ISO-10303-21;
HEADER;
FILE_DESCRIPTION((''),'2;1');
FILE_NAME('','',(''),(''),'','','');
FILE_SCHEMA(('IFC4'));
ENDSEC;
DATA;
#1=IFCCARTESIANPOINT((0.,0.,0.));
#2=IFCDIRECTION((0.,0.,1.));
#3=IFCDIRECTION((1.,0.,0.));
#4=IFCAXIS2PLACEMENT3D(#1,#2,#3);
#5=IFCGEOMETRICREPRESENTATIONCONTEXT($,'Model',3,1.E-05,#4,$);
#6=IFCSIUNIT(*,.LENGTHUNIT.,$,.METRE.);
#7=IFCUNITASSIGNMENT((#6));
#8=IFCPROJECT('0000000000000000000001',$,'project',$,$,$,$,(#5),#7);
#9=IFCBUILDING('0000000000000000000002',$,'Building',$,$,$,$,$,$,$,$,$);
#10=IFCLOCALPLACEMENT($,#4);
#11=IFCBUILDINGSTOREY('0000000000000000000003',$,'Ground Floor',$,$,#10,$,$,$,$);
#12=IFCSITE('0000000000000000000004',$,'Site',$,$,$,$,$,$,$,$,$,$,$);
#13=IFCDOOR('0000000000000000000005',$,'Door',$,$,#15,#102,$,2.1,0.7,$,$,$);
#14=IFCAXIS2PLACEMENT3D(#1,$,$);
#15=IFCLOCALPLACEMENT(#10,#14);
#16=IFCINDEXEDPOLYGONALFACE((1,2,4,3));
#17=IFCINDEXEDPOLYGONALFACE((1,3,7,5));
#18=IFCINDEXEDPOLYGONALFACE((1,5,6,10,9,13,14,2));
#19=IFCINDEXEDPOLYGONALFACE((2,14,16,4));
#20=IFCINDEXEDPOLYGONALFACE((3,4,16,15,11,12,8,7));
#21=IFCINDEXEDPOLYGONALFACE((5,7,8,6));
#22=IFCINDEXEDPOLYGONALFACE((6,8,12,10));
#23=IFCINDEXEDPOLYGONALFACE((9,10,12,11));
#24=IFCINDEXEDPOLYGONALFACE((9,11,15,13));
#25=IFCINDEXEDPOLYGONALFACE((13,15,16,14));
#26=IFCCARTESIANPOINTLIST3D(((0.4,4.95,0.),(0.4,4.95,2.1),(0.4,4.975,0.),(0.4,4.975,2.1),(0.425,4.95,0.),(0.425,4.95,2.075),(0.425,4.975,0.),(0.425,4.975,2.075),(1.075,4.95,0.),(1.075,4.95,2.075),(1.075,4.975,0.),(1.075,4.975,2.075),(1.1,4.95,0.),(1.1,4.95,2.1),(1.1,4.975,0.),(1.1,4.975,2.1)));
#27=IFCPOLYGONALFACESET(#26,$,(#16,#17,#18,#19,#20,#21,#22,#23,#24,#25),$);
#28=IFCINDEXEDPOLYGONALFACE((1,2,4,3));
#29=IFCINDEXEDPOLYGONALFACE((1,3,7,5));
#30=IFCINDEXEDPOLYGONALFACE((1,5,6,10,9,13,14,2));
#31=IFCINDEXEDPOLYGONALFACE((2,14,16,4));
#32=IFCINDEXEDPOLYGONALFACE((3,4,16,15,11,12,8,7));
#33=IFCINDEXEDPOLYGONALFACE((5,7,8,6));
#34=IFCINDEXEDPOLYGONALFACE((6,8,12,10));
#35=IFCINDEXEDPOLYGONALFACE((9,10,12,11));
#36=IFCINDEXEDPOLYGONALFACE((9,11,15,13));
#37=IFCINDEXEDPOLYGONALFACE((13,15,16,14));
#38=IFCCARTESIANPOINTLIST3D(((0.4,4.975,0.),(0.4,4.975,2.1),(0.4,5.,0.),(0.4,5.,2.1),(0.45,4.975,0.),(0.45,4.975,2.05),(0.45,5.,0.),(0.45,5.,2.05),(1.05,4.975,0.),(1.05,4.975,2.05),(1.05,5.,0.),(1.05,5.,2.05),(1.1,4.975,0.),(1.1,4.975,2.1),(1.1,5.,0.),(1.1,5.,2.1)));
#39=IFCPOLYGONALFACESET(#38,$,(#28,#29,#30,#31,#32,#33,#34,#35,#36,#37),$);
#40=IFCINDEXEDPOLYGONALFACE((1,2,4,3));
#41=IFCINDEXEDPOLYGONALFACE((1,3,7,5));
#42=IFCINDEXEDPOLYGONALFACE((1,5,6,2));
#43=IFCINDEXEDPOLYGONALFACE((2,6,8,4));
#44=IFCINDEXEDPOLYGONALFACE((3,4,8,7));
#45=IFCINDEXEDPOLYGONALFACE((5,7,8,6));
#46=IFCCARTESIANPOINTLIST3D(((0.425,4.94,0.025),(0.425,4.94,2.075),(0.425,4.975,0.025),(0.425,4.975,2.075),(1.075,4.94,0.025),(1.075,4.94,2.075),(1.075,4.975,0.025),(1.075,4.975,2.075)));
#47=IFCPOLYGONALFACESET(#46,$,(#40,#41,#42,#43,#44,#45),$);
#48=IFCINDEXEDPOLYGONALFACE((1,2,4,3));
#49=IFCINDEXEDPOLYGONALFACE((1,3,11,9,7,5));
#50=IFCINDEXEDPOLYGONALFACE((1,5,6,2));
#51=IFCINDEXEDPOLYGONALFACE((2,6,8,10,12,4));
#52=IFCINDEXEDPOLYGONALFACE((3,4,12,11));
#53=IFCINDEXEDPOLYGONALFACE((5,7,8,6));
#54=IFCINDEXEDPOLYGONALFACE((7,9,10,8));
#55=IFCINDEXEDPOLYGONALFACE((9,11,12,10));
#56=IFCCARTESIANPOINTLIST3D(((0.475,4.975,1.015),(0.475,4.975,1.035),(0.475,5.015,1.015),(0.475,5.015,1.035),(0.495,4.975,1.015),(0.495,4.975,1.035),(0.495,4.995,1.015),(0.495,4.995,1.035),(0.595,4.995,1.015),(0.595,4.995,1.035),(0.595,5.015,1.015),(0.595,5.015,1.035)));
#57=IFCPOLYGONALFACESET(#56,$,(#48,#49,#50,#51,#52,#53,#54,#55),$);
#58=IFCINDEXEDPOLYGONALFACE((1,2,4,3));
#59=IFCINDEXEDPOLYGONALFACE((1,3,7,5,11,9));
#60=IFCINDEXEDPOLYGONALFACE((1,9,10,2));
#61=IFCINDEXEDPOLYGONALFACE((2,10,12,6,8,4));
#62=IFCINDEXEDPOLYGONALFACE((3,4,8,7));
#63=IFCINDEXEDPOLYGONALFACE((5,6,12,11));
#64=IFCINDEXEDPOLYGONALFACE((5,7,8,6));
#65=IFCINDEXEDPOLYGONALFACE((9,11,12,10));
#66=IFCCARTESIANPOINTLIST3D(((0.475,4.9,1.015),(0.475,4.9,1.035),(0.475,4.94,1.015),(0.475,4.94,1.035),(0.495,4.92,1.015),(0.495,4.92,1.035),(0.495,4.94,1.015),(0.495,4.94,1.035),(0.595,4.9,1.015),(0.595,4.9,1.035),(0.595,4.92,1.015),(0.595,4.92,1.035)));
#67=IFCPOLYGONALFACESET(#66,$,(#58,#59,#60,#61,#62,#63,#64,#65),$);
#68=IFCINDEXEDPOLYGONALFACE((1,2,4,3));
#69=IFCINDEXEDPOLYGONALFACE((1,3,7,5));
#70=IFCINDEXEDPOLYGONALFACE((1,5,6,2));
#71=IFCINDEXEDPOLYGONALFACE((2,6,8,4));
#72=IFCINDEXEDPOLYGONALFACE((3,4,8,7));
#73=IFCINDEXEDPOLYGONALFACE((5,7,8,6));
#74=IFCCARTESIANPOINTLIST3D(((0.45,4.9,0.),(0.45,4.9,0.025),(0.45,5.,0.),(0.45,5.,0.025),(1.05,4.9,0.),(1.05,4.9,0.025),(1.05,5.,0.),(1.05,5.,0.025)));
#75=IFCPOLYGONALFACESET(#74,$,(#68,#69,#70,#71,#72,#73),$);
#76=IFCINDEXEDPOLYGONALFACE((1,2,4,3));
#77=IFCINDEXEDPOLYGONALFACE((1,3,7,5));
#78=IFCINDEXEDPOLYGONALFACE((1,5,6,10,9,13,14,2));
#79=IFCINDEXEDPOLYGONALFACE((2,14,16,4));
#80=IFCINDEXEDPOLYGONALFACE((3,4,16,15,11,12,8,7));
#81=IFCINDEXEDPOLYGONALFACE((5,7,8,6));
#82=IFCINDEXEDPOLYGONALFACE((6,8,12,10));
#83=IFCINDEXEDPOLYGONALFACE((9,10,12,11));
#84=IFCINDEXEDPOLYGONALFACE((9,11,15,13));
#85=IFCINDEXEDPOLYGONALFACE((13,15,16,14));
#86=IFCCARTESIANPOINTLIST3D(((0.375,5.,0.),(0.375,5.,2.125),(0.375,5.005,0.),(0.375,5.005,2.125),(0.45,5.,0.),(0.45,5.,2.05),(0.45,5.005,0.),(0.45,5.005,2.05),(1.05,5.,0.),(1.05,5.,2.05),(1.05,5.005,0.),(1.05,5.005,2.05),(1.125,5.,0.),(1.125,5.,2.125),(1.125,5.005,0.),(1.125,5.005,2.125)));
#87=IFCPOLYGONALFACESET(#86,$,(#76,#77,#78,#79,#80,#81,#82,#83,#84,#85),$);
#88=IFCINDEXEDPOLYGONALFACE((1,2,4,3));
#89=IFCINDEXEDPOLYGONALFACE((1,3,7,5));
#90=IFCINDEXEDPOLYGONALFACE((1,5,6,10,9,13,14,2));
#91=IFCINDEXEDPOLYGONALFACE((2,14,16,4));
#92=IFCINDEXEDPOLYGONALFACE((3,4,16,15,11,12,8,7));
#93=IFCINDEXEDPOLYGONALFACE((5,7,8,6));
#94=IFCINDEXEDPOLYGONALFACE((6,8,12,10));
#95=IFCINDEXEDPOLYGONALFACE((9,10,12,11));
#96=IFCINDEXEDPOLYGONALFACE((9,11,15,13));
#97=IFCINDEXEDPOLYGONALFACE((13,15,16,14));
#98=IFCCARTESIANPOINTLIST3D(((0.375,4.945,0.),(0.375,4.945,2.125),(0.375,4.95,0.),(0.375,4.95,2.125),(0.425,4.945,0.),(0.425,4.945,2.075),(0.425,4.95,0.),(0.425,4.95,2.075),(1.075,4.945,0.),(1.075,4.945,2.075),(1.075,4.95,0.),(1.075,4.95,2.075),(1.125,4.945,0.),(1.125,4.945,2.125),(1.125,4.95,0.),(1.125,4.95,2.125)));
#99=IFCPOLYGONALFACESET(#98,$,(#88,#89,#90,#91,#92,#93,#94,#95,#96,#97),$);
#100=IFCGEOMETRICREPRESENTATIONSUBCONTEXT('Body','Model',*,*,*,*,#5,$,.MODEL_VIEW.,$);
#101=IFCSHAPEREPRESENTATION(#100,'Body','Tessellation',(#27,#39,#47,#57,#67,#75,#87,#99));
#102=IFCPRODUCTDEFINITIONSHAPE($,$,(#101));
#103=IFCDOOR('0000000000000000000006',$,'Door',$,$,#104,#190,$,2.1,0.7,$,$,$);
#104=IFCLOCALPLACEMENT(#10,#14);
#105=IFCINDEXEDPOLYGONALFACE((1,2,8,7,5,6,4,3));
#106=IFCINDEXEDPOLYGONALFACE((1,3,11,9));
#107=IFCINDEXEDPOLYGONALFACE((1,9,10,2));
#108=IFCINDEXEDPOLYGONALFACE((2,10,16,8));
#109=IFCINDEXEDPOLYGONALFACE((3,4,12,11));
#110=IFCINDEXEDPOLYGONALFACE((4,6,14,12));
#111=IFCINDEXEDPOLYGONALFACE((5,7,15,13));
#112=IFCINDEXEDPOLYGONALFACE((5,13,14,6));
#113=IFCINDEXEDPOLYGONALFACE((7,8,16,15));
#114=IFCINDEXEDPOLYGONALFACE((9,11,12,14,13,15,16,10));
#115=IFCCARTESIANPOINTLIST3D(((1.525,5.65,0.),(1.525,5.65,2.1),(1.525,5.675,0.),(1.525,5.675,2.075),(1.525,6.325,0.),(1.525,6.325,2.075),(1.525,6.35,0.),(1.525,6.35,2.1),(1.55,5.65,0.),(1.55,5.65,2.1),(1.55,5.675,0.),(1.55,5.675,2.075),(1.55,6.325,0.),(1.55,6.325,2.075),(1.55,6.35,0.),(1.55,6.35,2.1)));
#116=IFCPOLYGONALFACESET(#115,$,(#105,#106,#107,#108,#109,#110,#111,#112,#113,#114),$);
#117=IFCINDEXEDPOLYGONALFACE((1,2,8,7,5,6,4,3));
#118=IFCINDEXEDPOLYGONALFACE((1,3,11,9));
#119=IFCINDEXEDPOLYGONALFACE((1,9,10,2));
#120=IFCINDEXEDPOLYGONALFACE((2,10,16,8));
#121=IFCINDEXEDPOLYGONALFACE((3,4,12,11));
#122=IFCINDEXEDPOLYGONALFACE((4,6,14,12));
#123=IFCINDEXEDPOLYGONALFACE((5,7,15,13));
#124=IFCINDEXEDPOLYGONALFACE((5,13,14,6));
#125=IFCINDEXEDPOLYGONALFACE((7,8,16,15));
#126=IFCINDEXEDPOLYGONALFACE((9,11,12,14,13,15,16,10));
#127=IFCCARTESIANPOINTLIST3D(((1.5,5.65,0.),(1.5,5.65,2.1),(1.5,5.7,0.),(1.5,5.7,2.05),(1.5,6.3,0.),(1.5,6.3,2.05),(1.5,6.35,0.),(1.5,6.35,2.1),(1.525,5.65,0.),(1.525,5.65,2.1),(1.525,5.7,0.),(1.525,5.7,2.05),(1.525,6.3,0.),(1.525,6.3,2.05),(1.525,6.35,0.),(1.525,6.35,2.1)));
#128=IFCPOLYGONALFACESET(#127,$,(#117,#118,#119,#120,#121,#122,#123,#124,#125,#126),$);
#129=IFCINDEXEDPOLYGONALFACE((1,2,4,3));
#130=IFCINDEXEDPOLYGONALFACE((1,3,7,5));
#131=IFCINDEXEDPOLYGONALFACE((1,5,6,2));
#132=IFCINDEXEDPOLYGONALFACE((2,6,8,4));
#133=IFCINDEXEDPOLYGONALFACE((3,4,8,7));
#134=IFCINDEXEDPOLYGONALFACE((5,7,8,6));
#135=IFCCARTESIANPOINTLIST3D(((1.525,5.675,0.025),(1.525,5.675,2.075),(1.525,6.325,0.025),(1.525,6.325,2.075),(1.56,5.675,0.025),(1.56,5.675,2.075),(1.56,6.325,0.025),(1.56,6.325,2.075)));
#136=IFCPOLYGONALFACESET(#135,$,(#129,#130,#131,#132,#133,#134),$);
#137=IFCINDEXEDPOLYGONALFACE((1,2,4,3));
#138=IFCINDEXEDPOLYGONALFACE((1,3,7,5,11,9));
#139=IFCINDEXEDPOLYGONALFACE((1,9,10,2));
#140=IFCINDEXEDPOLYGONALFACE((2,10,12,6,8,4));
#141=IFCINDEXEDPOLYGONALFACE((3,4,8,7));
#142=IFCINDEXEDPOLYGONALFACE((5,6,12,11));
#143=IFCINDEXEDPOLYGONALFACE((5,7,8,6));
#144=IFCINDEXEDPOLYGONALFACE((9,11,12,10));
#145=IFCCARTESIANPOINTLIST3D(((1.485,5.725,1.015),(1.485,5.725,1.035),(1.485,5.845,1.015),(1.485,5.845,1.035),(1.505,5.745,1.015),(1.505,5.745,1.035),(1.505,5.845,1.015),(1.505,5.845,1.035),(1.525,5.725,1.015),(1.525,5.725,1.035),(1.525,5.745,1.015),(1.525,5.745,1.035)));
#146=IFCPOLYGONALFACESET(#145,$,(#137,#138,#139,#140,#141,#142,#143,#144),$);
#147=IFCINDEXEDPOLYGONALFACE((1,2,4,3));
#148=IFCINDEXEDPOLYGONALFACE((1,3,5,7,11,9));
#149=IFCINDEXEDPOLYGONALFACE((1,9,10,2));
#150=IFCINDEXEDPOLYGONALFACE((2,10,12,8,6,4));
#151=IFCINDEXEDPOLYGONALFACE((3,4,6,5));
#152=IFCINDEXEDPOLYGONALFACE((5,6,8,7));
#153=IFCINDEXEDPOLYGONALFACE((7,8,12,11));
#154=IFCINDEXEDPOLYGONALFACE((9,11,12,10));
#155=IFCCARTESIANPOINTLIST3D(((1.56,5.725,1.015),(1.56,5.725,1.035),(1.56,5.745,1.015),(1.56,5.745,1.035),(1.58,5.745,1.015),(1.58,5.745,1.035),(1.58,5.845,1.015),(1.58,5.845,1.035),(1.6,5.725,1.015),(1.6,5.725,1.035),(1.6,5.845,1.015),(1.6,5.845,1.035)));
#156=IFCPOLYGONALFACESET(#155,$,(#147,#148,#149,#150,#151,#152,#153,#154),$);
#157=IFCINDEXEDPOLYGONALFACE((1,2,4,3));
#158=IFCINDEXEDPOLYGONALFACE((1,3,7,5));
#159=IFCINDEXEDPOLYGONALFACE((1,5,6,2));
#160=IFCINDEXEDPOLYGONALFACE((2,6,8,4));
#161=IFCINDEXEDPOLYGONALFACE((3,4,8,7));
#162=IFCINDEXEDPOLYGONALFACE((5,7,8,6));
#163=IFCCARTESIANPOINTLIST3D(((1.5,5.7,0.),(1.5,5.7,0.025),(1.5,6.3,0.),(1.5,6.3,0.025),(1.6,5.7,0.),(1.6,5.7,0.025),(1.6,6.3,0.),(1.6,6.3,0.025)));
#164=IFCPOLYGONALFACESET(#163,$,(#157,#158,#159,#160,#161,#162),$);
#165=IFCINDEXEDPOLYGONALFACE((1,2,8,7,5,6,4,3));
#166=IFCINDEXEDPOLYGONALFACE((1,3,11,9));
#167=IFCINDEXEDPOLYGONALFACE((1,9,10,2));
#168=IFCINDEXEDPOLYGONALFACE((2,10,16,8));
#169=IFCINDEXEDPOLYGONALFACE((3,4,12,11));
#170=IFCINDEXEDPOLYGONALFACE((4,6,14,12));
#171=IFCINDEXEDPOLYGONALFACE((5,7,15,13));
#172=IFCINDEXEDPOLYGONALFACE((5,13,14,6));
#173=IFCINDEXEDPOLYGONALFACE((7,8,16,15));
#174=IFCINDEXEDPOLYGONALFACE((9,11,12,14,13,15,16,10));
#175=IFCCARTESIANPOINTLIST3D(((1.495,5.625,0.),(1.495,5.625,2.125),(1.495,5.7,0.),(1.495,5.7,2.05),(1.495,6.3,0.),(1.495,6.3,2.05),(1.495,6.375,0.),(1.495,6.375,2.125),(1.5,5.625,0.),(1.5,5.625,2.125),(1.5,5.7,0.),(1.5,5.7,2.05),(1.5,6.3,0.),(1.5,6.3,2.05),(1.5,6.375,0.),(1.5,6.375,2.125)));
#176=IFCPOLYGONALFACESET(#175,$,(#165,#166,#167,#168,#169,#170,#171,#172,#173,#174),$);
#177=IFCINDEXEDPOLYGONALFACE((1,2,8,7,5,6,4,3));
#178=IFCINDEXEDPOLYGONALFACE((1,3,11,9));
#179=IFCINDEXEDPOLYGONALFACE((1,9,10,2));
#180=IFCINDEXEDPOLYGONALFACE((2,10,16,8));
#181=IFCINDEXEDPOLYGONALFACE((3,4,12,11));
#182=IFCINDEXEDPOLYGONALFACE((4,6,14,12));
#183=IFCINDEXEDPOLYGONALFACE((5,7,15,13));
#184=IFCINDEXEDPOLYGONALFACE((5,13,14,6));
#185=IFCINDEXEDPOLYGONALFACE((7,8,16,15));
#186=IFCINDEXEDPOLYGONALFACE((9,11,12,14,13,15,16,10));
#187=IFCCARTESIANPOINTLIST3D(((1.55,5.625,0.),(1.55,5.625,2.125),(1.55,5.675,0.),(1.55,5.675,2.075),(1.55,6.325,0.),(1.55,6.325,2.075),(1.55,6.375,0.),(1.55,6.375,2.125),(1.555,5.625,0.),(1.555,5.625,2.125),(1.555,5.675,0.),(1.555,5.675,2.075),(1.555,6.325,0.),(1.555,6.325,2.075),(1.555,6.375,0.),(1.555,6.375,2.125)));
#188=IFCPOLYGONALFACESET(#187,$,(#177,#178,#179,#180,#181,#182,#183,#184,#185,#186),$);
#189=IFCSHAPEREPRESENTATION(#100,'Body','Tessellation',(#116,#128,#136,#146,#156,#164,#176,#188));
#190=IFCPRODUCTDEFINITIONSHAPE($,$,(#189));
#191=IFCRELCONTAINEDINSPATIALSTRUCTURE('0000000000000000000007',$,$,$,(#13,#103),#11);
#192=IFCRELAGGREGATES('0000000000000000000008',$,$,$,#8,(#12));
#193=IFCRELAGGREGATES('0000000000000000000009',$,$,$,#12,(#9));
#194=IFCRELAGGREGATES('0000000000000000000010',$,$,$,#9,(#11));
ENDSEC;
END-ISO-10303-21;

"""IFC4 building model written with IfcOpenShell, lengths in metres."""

from ifc_helpers import new_model, si_unit, frame, origin_with_axes, place, context, subcontext, project, spatial, line, indexed_curve, outline, extrude, element, save


model = new_model("IFC4")

# Units and contexts
model_context = context("Model", 3, precision=1e-05, world=origin_with_axes())
body_context = subcontext(model_context, "Body", "Model", "MODEL_VIEW")
ifc_project = project(units=[si_unit("LENGTHUNIT", "METRE")], contexts=[model_context])

# Site, building, storey
site = spatial("IfcSite", under=ifc_project, Name="Site")
building = spatial("IfcBuilding", under=site, Name="Building")
storey_placement = place(None, origin_with_axes())
storey = spatial("IfcBuildingStorey", under=building, at=storey_placement, Name="Ground Floor")

# Doors
door_1_placement = place(storey_placement, frame((1.1, 5.0, 0.0), z_axis=(0.0, 0.0, 1.0), x_axis=(-1.0, 0.0, 0.0)))
element("IfcDoor", 1, at=door_1_placement, inside=storey, Name="Door", OverallHeight=2.1, OverallWidth=0.7, context=body_context, shape_type="SweptSolid", body=[
    extrude(outline(indexed_curve([(0.0, 0.0), (0.0, 2.1), (0.7, 2.1), (0.7, 0.0), (0.675, 0.0), (0.675, 2.075), (0.025, 2.075), (0.025, 0.0)], segments=[line(1, 2, 3, 4, 5, 6, 7, 8, 1)])), frame((0.0, 0.025, 0.0), z_axis=(0.0, -1.0, 0.0), x_axis=(1.0, 0.0, 0.0)), (0.0, 0.0, -1.0), 0.025),
    extrude(outline(indexed_curve([(0.0, 0.0), (0.0, 2.1), (0.7, 2.1), (0.7, 0.0), (0.65, 0.0), (0.65, 2.05), (0.05, 2.05), (0.05, 0.0)], segments=[line(1, 2, 3, 4, 5, 6, 7, 8, 1)])), frame((0.0, 0.0, 0.0), z_axis=(0.0, -1.0, 0.0), x_axis=(1.0, 0.0, 0.0)), (0.0, 0.0, -1.0), 0.025),
    extrude(outline(indexed_curve([(0.0, 0.0), (0.65, 0.0), (0.65, 0.035), (0.0, 0.035)], segments=[line(1, 2, 3, 4, 1)])), frame((0.025, 0.025, 0.025), z_axis=(0.0, 0.0, 1.0), x_axis=(1.0, 0.0, 0.0)), (0.0, 0.0, 1.0), 2.05),
    extrude(outline(indexed_curve([(0.0, 0.0), (0.0, -0.04), (-0.12, -0.04), (-0.12, -0.02), (-0.02, -0.02), (-0.02, 0.0)], segments=[line(1, 2, 3, 4, 5, 6, 1)])), frame((0.625, 0.025, 1.015), z_axis=(0.0, 0.0, 1.0), x_axis=(1.0, 0.0, 0.0)), (0.0, 0.0, 1.0), 0.02),
    extrude(outline(indexed_curve([(0.0, 0.0), (0.0, 0.04), (-0.12, 0.04), (-0.12, 0.02), (-0.02, 0.02), (-0.02, 0.0)], segments=[line(1, 2, 3, 4, 5, 6, 1)])), frame((0.625, 0.06, 1.015), z_axis=(0.0, 0.0, 1.0), x_axis=(1.0, 0.0, 0.0)), (0.0, 0.0, 1.0), 0.02),
    extrude(outline(indexed_curve([(0.0, 0.0), (0.6, 0.0), (0.6, 0.1), (0.0, 0.1)], segments=[line(1, 2, 3, 4, 1)])), frame((0.05, 0.0, 0.0), z_axis=(0.0, 0.0, 1.0), x_axis=(1.0, 0.0, 0.0)), (0.0, 0.0, 1.0), 0.025),
    extrude(outline(indexed_curve([(0.0, 0.0), (0.0, 2.125), (0.75, 2.125), (0.75, 0.0), (0.675, 0.0), (0.675, 2.05), (0.075, 2.05), (0.075, 0.0)], segments=[line(1, 2, 3, 4, 5, 6, 7, 8, 1)])), frame((-0.025, -0.005, 0.0), z_axis=(0.0, -1.0, 0.0), x_axis=(1.0, 0.0, 0.0)), (0.0, 0.0, -1.0), 0.005),
    extrude(outline(indexed_curve([(0.0, 0.0), (0.0, 2.125), (0.75, 2.125), (0.75, 0.0), (0.7, 0.0), (0.7, 2.075), (0.05, 2.075), (0.05, 0.0)], segments=[line(1, 2, 3, 4, 5, 6, 7, 8, 1)])), frame((-0.025, 0.05, 0.0), z_axis=(0.0, -1.0, 0.0), x_axis=(1.0, 0.0, 0.0)), (0.0, 0.0, -1.0), 0.005),
])
door_2_placement = place(storey_placement, frame((1.5, 6.35, 0.0), z_axis=(0.0, 0.0, 1.0), x_axis=(0.0, -1.0, 0.0)))
element("IfcDoor", 2, at=door_2_placement, inside=storey, Name="Door", OverallHeight=2.1, OverallWidth=0.7, context=body_context, shape_type="SweptSolid", body=[
    extrude(outline(indexed_curve([(0.0, 0.0), (0.0, 2.1), (0.7, 2.1), (0.7, 0.0), (0.675, 0.0), (0.675, 2.075), (0.025, 2.075), (0.025, 0.0)], segments=[line(1, 2, 3, 4, 5, 6, 7, 8, 1)])), frame((0.0, 0.025, 0.0), z_axis=(0.0, -1.0, 0.0), x_axis=(1.0, 0.0, 0.0)), (0.0, 0.0, -1.0), 0.025),
    extrude(outline(indexed_curve([(0.0, 0.0), (0.0, 2.1), (0.7, 2.1), (0.7, 0.0), (0.65, 0.0), (0.65, 2.05), (0.05, 2.05), (0.05, 0.0)], segments=[line(1, 2, 3, 4, 5, 6, 7, 8, 1)])), frame((0.0, 0.0, 0.0), z_axis=(0.0, -1.0, 0.0), x_axis=(1.0, 0.0, 0.0)), (0.0, 0.0, -1.0), 0.025),
    extrude(outline(indexed_curve([(0.0, 0.0), (0.65, 0.0), (0.65, 0.035), (0.0, 0.035)], segments=[line(1, 2, 3, 4, 1)])), frame((0.025, 0.025, 0.025), z_axis=(0.0, 0.0, 1.0), x_axis=(1.0, 0.0, 0.0)), (0.0, 0.0, 1.0), 2.05),
    extrude(outline(indexed_curve([(0.0, 0.0), (0.0, -0.04), (-0.12, -0.04), (-0.12, -0.02), (-0.02, -0.02), (-0.02, 0.0)], segments=[line(1, 2, 3, 4, 5, 6, 1)])), frame((0.625, 0.025, 1.015), z_axis=(0.0, 0.0, 1.0), x_axis=(1.0, 0.0, 0.0)), (0.0, 0.0, 1.0), 0.02),
    extrude(outline(indexed_curve([(0.0, 0.0), (0.0, 0.04), (-0.12, 0.04), (-0.12, 0.02), (-0.02, 0.02), (-0.02, 0.0)], segments=[line(1, 2, 3, 4, 5, 6, 1)])), frame((0.625, 0.06, 1.015), z_axis=(0.0, 0.0, 1.0), x_axis=(1.0, 0.0, 0.0)), (0.0, 0.0, 1.0), 0.02),
    extrude(outline(indexed_curve([(0.0, 0.0), (0.6, 0.0), (0.6, 0.1), (0.0, 0.1)], segments=[line(1, 2, 3, 4, 1)])), frame((0.05, 0.0, 0.0), z_axis=(0.0, 0.0, 1.0), x_axis=(1.0, 0.0, 0.0)), (0.0, 0.0, 1.0), 0.025),
    extrude(outline(indexed_curve([(0.0, 0.0), (0.0, 2.125), (0.75, 2.125), (0.75, 0.0), (0.675, 0.0), (0.675, 2.05), (0.075, 2.05), (0.075, 0.0)], segments=[line(1, 2, 3, 4, 5, 6, 7, 8, 1)])), frame((-0.025, -0.005, 0.0), z_axis=(0.0, -1.0, 0.0), x_axis=(1.0, 0.0, 0.0)), (0.0, 0.0, -1.0), 0.005),
    extrude(outline(indexed_curve([(0.0, 0.0), (0.0, 2.125), (0.75, 2.125), (0.75, 0.0), (0.7, 0.0), (0.7, 2.075), (0.05, 2.075), (0.05, 0.0)], segments=[line(1, 2, 3, 4, 5, 6, 7, 8, 1)])), frame((-0.025, 0.05, 0.0), z_axis=(0.0, -1.0, 0.0), x_axis=(1.0, 0.0, 0.0)), (0.0, 0.0, -1.0), 0.005),
])

save(model, "model.ifc")
